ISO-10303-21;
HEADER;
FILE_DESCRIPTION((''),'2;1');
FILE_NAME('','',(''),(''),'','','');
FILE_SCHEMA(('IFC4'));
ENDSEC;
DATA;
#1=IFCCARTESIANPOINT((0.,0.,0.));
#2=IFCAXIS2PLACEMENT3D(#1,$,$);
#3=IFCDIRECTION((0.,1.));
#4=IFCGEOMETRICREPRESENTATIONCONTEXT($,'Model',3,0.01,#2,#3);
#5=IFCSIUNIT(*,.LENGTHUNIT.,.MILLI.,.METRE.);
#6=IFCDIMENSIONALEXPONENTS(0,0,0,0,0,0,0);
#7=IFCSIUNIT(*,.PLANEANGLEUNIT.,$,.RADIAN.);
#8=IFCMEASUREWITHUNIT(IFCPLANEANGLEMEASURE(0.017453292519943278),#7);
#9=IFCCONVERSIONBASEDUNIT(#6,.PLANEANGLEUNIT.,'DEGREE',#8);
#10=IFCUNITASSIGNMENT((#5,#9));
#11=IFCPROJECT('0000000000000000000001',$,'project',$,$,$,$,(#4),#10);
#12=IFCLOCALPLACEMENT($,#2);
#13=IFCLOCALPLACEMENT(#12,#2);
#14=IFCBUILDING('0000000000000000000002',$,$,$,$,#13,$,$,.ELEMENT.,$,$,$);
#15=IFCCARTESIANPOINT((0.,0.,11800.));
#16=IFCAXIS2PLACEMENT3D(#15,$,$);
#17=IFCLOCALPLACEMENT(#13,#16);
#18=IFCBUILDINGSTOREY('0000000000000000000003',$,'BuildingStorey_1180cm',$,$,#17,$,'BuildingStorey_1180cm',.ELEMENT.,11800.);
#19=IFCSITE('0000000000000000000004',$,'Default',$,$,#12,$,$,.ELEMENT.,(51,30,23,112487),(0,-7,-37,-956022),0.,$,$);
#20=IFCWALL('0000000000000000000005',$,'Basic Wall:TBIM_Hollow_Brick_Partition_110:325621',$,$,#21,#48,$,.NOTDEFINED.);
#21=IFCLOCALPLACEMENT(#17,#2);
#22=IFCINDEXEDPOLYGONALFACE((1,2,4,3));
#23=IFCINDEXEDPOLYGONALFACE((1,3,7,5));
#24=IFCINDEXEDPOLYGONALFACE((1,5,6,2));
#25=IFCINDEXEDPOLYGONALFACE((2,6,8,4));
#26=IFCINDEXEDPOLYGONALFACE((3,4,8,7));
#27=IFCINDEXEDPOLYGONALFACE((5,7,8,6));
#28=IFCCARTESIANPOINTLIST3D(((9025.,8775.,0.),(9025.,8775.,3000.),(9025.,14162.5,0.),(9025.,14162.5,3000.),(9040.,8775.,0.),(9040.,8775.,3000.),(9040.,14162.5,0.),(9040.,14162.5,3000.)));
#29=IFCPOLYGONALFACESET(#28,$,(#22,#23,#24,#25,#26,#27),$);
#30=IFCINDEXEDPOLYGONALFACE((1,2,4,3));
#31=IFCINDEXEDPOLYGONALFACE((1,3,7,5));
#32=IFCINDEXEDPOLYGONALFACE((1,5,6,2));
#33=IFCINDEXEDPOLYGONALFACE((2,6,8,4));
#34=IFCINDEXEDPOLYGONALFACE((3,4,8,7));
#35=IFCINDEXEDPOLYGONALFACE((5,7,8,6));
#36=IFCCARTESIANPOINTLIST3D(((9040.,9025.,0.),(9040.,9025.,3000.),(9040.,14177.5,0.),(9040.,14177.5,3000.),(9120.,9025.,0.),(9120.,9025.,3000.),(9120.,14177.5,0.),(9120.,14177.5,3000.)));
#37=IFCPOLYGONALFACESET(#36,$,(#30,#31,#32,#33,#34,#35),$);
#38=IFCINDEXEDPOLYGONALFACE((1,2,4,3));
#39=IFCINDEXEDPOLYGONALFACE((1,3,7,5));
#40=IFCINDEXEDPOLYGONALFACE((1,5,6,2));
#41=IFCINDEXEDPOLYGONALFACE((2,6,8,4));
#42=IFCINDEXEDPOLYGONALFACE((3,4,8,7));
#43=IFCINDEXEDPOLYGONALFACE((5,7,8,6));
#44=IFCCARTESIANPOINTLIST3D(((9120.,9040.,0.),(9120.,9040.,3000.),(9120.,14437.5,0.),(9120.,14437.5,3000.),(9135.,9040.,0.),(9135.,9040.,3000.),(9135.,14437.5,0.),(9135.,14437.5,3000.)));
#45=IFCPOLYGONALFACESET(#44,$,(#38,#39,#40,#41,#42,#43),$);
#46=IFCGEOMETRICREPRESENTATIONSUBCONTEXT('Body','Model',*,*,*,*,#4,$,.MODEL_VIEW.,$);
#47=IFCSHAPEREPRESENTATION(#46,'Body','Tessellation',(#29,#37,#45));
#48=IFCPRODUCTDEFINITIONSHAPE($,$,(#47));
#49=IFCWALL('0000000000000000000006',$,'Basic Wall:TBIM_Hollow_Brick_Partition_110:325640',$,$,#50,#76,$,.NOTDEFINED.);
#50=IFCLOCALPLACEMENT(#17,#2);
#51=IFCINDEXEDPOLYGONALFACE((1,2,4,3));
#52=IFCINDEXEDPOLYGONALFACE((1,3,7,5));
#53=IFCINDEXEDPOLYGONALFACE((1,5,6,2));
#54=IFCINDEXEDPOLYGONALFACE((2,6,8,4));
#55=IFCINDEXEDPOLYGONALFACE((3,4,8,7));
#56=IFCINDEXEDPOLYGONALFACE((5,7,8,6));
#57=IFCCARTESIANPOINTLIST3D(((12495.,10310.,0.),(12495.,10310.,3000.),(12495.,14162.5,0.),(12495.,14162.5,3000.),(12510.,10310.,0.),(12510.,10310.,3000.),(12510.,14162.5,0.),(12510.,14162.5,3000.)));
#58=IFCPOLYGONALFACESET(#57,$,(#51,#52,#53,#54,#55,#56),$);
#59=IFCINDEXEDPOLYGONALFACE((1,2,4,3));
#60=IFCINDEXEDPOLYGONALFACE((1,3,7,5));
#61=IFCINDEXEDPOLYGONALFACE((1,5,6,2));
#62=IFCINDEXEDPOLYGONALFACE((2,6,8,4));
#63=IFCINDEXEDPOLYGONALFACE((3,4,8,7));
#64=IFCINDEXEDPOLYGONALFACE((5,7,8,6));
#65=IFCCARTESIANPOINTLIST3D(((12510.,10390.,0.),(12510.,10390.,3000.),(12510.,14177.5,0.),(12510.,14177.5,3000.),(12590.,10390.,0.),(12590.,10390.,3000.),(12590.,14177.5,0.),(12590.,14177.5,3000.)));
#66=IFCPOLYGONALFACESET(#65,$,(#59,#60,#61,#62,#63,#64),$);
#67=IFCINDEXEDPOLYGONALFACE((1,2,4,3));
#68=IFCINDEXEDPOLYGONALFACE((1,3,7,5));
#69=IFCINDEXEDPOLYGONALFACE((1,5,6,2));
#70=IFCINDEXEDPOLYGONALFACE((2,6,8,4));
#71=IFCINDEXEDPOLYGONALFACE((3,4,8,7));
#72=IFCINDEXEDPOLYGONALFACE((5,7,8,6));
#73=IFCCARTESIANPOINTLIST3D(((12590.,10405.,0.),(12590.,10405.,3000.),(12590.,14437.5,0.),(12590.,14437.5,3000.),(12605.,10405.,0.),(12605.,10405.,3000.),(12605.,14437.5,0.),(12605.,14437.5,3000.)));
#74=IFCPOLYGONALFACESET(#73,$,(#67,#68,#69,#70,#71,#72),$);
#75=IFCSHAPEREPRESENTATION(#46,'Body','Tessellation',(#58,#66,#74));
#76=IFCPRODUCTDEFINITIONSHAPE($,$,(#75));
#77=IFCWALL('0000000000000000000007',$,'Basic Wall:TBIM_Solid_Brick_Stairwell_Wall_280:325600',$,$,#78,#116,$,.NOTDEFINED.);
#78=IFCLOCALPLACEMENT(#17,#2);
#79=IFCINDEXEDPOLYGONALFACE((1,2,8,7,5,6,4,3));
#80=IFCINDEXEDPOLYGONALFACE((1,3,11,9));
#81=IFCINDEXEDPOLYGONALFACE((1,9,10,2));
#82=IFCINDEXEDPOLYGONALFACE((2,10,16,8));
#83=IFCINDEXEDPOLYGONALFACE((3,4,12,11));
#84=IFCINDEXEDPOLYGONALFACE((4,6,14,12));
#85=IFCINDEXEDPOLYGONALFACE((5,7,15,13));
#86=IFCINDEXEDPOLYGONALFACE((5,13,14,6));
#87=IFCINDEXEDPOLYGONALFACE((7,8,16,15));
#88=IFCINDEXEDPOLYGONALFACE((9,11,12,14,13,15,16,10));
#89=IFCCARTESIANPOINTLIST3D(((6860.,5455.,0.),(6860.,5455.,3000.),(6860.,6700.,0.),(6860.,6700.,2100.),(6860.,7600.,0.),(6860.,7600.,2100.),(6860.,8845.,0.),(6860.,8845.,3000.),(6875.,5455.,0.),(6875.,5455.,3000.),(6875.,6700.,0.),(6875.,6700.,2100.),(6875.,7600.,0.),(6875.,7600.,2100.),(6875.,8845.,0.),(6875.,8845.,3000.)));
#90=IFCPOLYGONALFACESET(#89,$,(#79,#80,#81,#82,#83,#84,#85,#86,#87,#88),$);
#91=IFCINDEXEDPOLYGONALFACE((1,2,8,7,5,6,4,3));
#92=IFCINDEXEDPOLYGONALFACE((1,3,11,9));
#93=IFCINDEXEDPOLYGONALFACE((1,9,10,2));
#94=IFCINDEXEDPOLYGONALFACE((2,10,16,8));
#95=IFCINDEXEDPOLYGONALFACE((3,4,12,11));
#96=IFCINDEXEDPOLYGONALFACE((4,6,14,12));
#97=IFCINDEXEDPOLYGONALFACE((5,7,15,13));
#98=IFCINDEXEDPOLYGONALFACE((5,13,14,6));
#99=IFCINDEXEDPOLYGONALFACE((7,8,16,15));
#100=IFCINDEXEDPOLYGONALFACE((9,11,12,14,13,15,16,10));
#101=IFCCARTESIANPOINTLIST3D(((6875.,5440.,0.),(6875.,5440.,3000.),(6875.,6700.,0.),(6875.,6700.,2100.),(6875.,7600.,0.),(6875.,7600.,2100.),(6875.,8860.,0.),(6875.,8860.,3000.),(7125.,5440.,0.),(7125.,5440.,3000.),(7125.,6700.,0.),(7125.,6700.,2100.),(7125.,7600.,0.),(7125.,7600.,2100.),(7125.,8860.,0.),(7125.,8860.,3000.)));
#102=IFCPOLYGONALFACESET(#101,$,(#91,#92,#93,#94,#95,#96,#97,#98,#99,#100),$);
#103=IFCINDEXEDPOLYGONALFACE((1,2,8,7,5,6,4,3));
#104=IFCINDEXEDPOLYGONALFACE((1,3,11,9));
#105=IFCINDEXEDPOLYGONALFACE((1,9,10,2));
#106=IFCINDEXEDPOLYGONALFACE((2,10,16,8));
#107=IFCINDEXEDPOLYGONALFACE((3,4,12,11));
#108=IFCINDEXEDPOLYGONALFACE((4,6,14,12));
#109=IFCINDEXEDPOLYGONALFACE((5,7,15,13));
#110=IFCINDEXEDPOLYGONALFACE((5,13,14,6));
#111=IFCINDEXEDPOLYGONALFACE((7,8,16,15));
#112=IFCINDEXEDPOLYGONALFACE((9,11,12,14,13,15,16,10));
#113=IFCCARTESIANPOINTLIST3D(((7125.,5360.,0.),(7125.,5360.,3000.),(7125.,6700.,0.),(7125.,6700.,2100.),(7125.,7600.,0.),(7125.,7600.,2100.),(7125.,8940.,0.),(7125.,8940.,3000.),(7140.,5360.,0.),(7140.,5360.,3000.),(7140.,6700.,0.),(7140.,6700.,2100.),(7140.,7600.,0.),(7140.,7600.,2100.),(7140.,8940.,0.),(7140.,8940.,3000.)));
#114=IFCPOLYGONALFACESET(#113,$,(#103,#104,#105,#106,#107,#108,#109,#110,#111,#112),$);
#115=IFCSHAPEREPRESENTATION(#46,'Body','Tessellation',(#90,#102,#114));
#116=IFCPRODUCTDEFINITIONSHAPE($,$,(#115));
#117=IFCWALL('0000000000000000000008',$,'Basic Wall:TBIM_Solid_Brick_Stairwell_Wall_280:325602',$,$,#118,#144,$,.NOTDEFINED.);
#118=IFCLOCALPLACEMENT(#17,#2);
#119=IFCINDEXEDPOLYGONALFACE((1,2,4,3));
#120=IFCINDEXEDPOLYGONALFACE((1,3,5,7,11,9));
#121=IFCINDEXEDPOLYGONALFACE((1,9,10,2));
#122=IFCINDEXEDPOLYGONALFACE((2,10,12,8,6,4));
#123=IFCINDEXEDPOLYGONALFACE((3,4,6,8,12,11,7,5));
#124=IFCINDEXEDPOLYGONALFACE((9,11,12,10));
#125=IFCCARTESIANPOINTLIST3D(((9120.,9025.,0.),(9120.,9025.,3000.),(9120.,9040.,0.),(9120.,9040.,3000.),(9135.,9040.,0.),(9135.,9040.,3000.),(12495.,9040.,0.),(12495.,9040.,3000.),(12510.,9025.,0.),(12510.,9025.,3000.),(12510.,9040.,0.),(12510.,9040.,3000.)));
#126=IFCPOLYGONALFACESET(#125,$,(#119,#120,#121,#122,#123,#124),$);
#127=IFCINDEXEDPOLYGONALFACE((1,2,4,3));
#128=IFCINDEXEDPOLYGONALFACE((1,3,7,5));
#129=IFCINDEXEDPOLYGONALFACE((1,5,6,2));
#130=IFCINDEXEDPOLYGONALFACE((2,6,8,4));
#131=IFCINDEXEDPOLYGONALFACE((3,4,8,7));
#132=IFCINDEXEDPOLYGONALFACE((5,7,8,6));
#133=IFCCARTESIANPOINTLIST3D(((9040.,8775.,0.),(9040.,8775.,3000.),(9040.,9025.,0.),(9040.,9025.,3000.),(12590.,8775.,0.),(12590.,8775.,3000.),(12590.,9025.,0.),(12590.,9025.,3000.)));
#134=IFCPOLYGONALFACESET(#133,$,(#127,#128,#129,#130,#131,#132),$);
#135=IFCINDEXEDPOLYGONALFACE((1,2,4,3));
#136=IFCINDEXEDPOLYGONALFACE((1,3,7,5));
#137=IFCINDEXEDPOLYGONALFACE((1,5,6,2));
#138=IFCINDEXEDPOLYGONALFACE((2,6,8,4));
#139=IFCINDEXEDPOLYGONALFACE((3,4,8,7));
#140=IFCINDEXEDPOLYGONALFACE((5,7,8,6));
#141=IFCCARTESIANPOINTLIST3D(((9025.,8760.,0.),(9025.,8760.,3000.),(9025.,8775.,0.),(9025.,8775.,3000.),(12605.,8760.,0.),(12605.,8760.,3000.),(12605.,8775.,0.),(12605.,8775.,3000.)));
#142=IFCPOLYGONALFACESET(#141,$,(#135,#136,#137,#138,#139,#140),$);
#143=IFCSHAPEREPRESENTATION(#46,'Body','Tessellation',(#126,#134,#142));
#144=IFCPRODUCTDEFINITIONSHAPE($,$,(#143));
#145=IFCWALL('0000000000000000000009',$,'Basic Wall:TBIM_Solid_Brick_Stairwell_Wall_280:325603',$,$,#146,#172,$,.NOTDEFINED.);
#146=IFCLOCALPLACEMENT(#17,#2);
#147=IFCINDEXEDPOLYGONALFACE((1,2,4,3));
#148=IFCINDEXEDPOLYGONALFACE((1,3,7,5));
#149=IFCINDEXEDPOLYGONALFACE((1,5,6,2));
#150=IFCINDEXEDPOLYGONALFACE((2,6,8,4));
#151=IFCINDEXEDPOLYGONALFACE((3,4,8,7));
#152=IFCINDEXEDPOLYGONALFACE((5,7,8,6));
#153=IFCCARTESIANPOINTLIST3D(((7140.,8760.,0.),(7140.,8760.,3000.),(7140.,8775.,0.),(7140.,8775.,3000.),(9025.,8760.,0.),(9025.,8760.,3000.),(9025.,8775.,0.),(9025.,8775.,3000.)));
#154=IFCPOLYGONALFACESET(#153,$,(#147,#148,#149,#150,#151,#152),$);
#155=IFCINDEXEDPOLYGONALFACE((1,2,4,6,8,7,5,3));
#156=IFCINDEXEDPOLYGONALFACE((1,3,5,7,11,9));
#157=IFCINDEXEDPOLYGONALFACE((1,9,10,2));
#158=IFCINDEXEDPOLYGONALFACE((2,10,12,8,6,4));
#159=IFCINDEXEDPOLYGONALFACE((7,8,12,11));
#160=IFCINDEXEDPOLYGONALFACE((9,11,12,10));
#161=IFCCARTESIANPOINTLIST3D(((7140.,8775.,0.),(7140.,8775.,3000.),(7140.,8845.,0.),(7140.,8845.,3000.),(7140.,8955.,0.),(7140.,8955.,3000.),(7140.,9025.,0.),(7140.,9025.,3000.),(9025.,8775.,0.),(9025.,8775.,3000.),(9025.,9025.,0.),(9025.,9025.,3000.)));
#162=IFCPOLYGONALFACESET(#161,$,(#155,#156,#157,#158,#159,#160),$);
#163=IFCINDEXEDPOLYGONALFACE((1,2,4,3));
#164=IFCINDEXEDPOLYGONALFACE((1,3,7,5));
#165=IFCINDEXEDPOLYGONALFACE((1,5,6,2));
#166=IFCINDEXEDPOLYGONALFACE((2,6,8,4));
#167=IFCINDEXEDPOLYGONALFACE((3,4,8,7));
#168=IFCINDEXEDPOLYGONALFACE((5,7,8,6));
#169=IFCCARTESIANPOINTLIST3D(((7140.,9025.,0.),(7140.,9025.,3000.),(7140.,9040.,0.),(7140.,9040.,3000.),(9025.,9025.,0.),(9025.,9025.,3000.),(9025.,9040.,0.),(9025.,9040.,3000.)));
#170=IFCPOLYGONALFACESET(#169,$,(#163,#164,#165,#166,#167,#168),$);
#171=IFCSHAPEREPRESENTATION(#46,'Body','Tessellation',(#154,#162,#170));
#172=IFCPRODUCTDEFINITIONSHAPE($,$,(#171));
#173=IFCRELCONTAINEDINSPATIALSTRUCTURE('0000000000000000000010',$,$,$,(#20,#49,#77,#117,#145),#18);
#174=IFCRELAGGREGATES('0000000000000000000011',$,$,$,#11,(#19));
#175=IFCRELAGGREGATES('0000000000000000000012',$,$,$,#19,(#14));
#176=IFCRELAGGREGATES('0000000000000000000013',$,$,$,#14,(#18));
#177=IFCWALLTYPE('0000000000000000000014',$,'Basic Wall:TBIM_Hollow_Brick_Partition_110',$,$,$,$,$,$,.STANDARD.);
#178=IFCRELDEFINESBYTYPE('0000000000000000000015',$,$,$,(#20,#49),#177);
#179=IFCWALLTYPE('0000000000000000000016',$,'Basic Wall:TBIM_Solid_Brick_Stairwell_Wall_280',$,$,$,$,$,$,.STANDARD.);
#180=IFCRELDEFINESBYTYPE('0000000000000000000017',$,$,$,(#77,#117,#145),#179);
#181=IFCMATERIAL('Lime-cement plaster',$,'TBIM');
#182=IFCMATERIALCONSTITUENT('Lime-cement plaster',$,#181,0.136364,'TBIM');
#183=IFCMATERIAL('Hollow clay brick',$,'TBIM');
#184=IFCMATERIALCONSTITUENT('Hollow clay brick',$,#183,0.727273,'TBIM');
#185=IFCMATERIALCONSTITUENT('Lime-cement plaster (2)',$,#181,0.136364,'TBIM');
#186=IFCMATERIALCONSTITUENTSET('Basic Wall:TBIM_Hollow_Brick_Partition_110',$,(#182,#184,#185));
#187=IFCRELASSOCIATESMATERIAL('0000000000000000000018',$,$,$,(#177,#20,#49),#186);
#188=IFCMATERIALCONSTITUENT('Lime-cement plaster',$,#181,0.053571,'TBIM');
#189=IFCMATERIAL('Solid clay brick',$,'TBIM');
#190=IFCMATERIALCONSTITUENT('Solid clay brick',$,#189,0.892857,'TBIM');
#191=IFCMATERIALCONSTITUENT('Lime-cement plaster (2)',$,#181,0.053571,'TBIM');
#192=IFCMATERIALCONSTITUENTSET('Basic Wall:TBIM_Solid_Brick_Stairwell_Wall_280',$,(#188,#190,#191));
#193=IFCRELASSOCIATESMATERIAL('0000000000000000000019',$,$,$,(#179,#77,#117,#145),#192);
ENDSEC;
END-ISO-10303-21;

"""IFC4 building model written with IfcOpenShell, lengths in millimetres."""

from ifc_helpers import new_model, entity, si_unit, converted_unit, direction, frame, origin, place, context, subcontext, project, spatial, indexed_curve, outline, extrude, material, constituent, constituent_set, type_object, element, save


model = new_model("IFC4")

# Units and contexts
model_context = context("Model", 3, precision=0.01, world=origin(), true_north=direction((0.0, 1.0)))
body_context = subcontext(model_context, "Body", "Model", "MODEL_VIEW")
ifc_project = project(units=[si_unit("LENGTHUNIT", "METRE", prefix="MILLI"), converted_unit("PLANEANGLEUNIT", "DEGREE", entity("IfcPlaneAngleMeasure", 0.017453292519943278), si_unit("PLANEANGLEUNIT", "RADIAN"), dimensions=[0, 0, 0, 0, 0, 0, 0])], contexts=[model_context])

# Site, building, storey
site_placement = place(None, origin())
site = spatial("IfcSite", under=ifc_project, at=site_placement, Name="Default", CompositionType="ELEMENT", RefLatitude=(51, 30, 23, 112487), RefLongitude=(0, -7, -37, -956022), RefElevation=0.0)
building_placement = place(site_placement, origin())
building = spatial("IfcBuilding", under=site, at=building_placement, CompositionType="ELEMENT")
storey_placement = place(building_placement, frame((0.0, 0.0, 11800.0)))
storey = spatial("IfcBuildingStorey", under=building, at=storey_placement, Name="BuildingStorey_1180cm", LongName="BuildingStorey_1180cm", CompositionType="ELEMENT", Elevation=11800.0)

# Shared definitions
ifc_material_1 = material(Name="Hollow clay brick", Category="TBIM")
ifc_material_2 = material(Name="Lime-cement plaster", Category="TBIM")
ifc_constituent_1 = constituent(ifc_material_2, Name="Lime-cement plaster", Category="TBIM", fraction=0.136364)
ifc_constituent_2 = constituent(ifc_material_1, Name="Hollow clay brick", Category="TBIM", fraction=0.727273)
ifc_constituent_3 = constituent(ifc_material_2, Name="Lime-cement plaster (2)", Category="TBIM", fraction=0.136364)
ifc_constituent_set_1 = constituent_set(constituents=[ifc_constituent_1, ifc_constituent_2, ifc_constituent_3], Name="Basic Wall:TBIM_Hollow_Brick_Partition_110")
wall_type_1 = type_object("IfcWallType", Name="Basic Wall:TBIM_Hollow_Brick_Partition_110", PredefinedType="STANDARD", material=ifc_constituent_set_1)

# Walls
wall_1_placement = place(storey_placement, frame((9080.0, 9040.0, 0.0), z_axis=(0.0, 0.0, 1.0), x_axis=(0.0, 1.0, 0.0)))
element("IfcWall", 1, at=wall_1_placement, inside=storey, type_object=wall_type_1, material=ifc_constituent_set_1, Name="Basic Wall:TBIM_Hollow_Brick_Partition_110:325621", PredefinedType="NOTDEFINED", context=body_context, shape_type="SweptSolid", body=[
    extrude(outline(indexed_curve([(-7.5, -2693.7), (7.5, -2693.7), (7.5, 2693.8), (-7.5, 2693.8), (-7.5, -2693.7)], self_intersect=False)), frame((2428.7, 47.5, 0.0), z_axis=(0.0, 0.0, 1.0), x_axis=(0.0, -1.0, 0.0)), (0.0, 0.0, 1.0), 3000.0),
    extrude(outline(indexed_curve([(-2576.2, -40.0), (2576.3, -40.0), (2576.3, 40.0), (-2576.2, 40.0), (-2576.2, -40.0)], self_intersect=False)), frame((2561.2, 0.0, 0.0)), (0.0, 0.0, 1.0), 3000.0),
    extrude(outline(indexed_curve([(-7.5, -2698.7), (7.5, -2698.7), (7.5, 2698.8), (-7.5, 2698.8), (-7.5, -2698.7)], self_intersect=False)), frame((2698.8, -47.5, 0.0), z_axis=(0.0, 0.0, 1.0), x_axis=(0.0, 1.0, 0.0)), (0.0, 0.0, 1.0), 3000.0),
])
wall_2_placement = place(storey_placement, frame((12550.0, 10405.0, 0.0), z_axis=(0.0, 0.0, 1.0), x_axis=(0.0, 1.0, 0.0)))
element("IfcWall", 2, at=wall_2_placement, inside=storey, type_object=wall_type_1, material=ifc_constituent_set_1, Name="Basic Wall:TBIM_Hollow_Brick_Partition_110:325640", PredefinedType="NOTDEFINED", context=body_context, shape_type="SweptSolid", body=[
    extrude(outline(indexed_curve([(-7.5, -1926.2), (7.5, -1926.2), (7.5, 1926.2), (-7.5, 1926.2), (-7.5, -1926.2)], self_intersect=False)), frame((1831.2, 47.5, 0.0), z_axis=(0.0, 0.0, 1.0), x_axis=(0.0, -1.0, 0.0)), (0.0, 0.0, 1.0), 3000.0),
    extrude(outline(indexed_curve([(-1893.8, -40.0), (1893.8, -40.0), (1893.8, 40.0), (-1893.8, 40.0), (-1893.8, -40.0)], self_intersect=False)), frame((1878.7, 0.0, 0.0)), (0.0, 0.0, 1.0), 3000.0),
    extrude(outline(indexed_curve([(-7.5, -2016.3), (7.5, -2016.3), (7.5, 2016.2), (-7.5, 2016.2), (-7.5, -2016.3)], self_intersect=False)), frame((2016.2, -47.5, 0.0), z_axis=(0.0, 0.0, 1.0), x_axis=(0.0, 1.0, 0.0)), (0.0, 0.0, 1.0), 3000.0),
])
ifc_constituent_4 = constituent(ifc_material_2, Name="Lime-cement plaster", Category="TBIM", fraction=0.053571)
ifc_material_3 = material(Name="Solid clay brick", Category="TBIM")
ifc_constituent_5 = constituent(ifc_material_3, Name="Solid clay brick", Category="TBIM", fraction=0.892857)
ifc_constituent_6 = constituent(ifc_material_2, Name="Lime-cement plaster (2)", Category="TBIM", fraction=0.053571)
ifc_constituent_set_2 = constituent_set(constituents=[ifc_constituent_4, ifc_constituent_5, ifc_constituent_6], Name="Basic Wall:TBIM_Solid_Brick_Stairwell_Wall_280")
wall_type_2 = type_object("IfcWallType", Name="Basic Wall:TBIM_Solid_Brick_Stairwell_Wall_280", PredefinedType="STANDARD", material=ifc_constituent_set_2)

# Wall, opening
wall_3_placement = place(storey_placement, frame((7000.0, 5455.0, 0.0), z_axis=(0.0, 0.0, 1.0), x_axis=(0.0, 1.0, 0.0)))
wall_3 = element("IfcWall", 3, at=wall_3_placement, inside=storey, type_object=wall_type_2, material=ifc_constituent_set_2, Name="Basic Wall:TBIM_Solid_Brick_Stairwell_Wall_280:325600", PredefinedType="NOTDEFINED", context=body_context, shape_type="SweptSolid", body=[
    extrude(outline(indexed_curve([(-1725.0, -1695.0), (1275.0, -1695.0), (1275.0, -450.0), (-825.0, -450.0), (-825.0, 450.0), (1275.0, 450.0), (1275.0, 1695.0), (-1725.0, 1695.0), (-1725.0, -1695.0)], self_intersect=False)), frame((1695.0, 140.0, 1275.0), z_axis=(0.0, -1.0, 0.0), x_axis=(0.0, 0.0, -1.0)), (0.0, 0.0, 1.0), 15.0),
    extrude(outline(indexed_curve([(-1275.0, -450.0), (-1275.0, -1710.0), (1725.0, -1710.0), (1725.0, 1710.0), (-1275.0, 1710.0), (-1275.0, 450.0), (825.0, 450.0), (825.0, -450.0), (-1275.0, -450.0)], self_intersect=False)), frame((1695.0, 125.0, 1275.0), z_axis=(0.0, 1.0, 0.0), x_axis=(0.0, 0.0, 1.0)), (0.0, 0.0, -1.0), 250.0),
    extrude(outline(indexed_curve([(-1275.0, -450.0), (-1275.0, -1790.0), (1725.0, -1790.0), (1725.0, 1790.0), (-1275.0, 1790.0), (-1275.0, 450.0), (825.0, 450.0), (825.0, -450.0), (-1275.0, -450.0)], self_intersect=False)), frame((1695.0, -125.0, 1275.0), z_axis=(0.0, 1.0, 0.0), x_axis=(0.0, 0.0, 1.0)), (0.0, 0.0, -1.0), 15.0),
])
opening_1_placement = place(wall_3_placement, frame((1245.0, -140.0, 0.0)))
element("IfcOpeningElement", 4, at=opening_1_placement, cuts=wall_3, PredefinedType="OPENING", context=body_context, shape_type="SweptSolid", body=[
    extrude(outline(indexed_curve([(0.0, 900.0), (0.0, 0.0), (2100.0, 0.0), (2100.0, 900.0), (0.0, 900.0)], self_intersect=False)), frame((0.0, 0.0, 0.0), z_axis=(0.0, 1.0, 0.0), x_axis=(0.0, 0.0, 1.0)), (0.0, 0.0, 1.0), 280.0),
])

# Walls
wall_4_placement = place(storey_placement, frame((9025.0, 8900.0, 0.0)))
element("IfcWall", 5, at=wall_4_placement, inside=storey, type_object=wall_type_2, material=ifc_constituent_set_2, Name="Basic Wall:TBIM_Solid_Brick_Stairwell_Wall_280:325602", PredefinedType="NOTDEFINED", context=body_context, shape_type="SweptSolid", body=[
    extrude(outline(indexed_curve([(-1680.0, -5.0), (1680.0, -5.0), (1695.0, -5.0), (1695.0, 10.0), (-1695.0, 10.0), (-1695.0, -5.0), (-1680.0, -5.0)], self_intersect=False)), frame((1790.0, 135.0, 0.0), z_axis=(0.0, 0.0, 1.0), x_axis=(-1.0, 0.0, 0.0)), (0.0, 0.0, 1.0), 3000.0),
    extrude(outline(indexed_curve([(-1775.0, -125.0), (1775.0, -125.0), (1775.0, 125.0), (-1775.0, 125.0), (-1775.0, -125.0)], self_intersect=False)), frame((1790.0, 0.0, 0.0)), (0.0, 0.0, 1.0), 3000.0),
    extrude(outline(indexed_curve([(-7.5, -1790.0), (7.5, -1790.0), (7.5, 1790.0), (-7.5, 1790.0), (-7.5, -1790.0)], self_intersect=False)), frame((1790.0, -132.5, 0.0), z_axis=(0.0, 0.0, 1.0), x_axis=(0.0, 1.0, 0.0)), (0.0, 0.0, 1.0), 3000.0),
])
wall_5_placement = place(storey_placement, frame((9025.0, 8900.0, 0.0), z_axis=(0.0, 0.0, 1.0), x_axis=(-1.0, 0.0, 0.0)))
element("IfcWall", 6, at=wall_5_placement, inside=storey, type_object=wall_type_2, material=ifc_constituent_set_2, Name="Basic Wall:TBIM_Solid_Brick_Stairwell_Wall_280:325603", PredefinedType="NOTDEFINED", context=body_context, shape_type="SweptSolid", body=[
    extrude(outline(indexed_curve([(-7.5, -942.5), (7.5, -942.5), (7.5, 942.5), (-7.5, 942.5), (-7.5, -942.5)], self_intersect=False)), frame((942.5, 132.5, 0.0), z_axis=(0.0, 0.0, 1.0), x_axis=(0.0, -1.0, 0.0)), (0.0, 0.0, 1.0), 3000.0),
    extrude(outline(indexed_curve([(55.0, -628.3), (125.0, -628.3), (125.0, 1256.7), (-125.0, 1256.7), (-125.0, -628.3), (-55.0, -628.3), (55.0, -628.3)], self_intersect=False)), frame((1256.7, 0.0, 0.0), z_axis=(0.0, 0.0, 1.0), x_axis=(0.0, 1.0, 0.0)), (0.0, 0.0, 1.0), 3000.0),
    extrude(outline(indexed_curve([(-7.5, -942.5), (7.5, -942.5), (7.5, 942.5), (-7.5, 942.5), (-7.5, -942.5)], self_intersect=False)), frame((942.5, -132.5, 0.0), z_axis=(0.0, 0.0, 1.0), x_axis=(0.0, 1.0, 0.0)), (0.0, 0.0, 1.0), 3000.0),
])

save(model, "model.ifc")
